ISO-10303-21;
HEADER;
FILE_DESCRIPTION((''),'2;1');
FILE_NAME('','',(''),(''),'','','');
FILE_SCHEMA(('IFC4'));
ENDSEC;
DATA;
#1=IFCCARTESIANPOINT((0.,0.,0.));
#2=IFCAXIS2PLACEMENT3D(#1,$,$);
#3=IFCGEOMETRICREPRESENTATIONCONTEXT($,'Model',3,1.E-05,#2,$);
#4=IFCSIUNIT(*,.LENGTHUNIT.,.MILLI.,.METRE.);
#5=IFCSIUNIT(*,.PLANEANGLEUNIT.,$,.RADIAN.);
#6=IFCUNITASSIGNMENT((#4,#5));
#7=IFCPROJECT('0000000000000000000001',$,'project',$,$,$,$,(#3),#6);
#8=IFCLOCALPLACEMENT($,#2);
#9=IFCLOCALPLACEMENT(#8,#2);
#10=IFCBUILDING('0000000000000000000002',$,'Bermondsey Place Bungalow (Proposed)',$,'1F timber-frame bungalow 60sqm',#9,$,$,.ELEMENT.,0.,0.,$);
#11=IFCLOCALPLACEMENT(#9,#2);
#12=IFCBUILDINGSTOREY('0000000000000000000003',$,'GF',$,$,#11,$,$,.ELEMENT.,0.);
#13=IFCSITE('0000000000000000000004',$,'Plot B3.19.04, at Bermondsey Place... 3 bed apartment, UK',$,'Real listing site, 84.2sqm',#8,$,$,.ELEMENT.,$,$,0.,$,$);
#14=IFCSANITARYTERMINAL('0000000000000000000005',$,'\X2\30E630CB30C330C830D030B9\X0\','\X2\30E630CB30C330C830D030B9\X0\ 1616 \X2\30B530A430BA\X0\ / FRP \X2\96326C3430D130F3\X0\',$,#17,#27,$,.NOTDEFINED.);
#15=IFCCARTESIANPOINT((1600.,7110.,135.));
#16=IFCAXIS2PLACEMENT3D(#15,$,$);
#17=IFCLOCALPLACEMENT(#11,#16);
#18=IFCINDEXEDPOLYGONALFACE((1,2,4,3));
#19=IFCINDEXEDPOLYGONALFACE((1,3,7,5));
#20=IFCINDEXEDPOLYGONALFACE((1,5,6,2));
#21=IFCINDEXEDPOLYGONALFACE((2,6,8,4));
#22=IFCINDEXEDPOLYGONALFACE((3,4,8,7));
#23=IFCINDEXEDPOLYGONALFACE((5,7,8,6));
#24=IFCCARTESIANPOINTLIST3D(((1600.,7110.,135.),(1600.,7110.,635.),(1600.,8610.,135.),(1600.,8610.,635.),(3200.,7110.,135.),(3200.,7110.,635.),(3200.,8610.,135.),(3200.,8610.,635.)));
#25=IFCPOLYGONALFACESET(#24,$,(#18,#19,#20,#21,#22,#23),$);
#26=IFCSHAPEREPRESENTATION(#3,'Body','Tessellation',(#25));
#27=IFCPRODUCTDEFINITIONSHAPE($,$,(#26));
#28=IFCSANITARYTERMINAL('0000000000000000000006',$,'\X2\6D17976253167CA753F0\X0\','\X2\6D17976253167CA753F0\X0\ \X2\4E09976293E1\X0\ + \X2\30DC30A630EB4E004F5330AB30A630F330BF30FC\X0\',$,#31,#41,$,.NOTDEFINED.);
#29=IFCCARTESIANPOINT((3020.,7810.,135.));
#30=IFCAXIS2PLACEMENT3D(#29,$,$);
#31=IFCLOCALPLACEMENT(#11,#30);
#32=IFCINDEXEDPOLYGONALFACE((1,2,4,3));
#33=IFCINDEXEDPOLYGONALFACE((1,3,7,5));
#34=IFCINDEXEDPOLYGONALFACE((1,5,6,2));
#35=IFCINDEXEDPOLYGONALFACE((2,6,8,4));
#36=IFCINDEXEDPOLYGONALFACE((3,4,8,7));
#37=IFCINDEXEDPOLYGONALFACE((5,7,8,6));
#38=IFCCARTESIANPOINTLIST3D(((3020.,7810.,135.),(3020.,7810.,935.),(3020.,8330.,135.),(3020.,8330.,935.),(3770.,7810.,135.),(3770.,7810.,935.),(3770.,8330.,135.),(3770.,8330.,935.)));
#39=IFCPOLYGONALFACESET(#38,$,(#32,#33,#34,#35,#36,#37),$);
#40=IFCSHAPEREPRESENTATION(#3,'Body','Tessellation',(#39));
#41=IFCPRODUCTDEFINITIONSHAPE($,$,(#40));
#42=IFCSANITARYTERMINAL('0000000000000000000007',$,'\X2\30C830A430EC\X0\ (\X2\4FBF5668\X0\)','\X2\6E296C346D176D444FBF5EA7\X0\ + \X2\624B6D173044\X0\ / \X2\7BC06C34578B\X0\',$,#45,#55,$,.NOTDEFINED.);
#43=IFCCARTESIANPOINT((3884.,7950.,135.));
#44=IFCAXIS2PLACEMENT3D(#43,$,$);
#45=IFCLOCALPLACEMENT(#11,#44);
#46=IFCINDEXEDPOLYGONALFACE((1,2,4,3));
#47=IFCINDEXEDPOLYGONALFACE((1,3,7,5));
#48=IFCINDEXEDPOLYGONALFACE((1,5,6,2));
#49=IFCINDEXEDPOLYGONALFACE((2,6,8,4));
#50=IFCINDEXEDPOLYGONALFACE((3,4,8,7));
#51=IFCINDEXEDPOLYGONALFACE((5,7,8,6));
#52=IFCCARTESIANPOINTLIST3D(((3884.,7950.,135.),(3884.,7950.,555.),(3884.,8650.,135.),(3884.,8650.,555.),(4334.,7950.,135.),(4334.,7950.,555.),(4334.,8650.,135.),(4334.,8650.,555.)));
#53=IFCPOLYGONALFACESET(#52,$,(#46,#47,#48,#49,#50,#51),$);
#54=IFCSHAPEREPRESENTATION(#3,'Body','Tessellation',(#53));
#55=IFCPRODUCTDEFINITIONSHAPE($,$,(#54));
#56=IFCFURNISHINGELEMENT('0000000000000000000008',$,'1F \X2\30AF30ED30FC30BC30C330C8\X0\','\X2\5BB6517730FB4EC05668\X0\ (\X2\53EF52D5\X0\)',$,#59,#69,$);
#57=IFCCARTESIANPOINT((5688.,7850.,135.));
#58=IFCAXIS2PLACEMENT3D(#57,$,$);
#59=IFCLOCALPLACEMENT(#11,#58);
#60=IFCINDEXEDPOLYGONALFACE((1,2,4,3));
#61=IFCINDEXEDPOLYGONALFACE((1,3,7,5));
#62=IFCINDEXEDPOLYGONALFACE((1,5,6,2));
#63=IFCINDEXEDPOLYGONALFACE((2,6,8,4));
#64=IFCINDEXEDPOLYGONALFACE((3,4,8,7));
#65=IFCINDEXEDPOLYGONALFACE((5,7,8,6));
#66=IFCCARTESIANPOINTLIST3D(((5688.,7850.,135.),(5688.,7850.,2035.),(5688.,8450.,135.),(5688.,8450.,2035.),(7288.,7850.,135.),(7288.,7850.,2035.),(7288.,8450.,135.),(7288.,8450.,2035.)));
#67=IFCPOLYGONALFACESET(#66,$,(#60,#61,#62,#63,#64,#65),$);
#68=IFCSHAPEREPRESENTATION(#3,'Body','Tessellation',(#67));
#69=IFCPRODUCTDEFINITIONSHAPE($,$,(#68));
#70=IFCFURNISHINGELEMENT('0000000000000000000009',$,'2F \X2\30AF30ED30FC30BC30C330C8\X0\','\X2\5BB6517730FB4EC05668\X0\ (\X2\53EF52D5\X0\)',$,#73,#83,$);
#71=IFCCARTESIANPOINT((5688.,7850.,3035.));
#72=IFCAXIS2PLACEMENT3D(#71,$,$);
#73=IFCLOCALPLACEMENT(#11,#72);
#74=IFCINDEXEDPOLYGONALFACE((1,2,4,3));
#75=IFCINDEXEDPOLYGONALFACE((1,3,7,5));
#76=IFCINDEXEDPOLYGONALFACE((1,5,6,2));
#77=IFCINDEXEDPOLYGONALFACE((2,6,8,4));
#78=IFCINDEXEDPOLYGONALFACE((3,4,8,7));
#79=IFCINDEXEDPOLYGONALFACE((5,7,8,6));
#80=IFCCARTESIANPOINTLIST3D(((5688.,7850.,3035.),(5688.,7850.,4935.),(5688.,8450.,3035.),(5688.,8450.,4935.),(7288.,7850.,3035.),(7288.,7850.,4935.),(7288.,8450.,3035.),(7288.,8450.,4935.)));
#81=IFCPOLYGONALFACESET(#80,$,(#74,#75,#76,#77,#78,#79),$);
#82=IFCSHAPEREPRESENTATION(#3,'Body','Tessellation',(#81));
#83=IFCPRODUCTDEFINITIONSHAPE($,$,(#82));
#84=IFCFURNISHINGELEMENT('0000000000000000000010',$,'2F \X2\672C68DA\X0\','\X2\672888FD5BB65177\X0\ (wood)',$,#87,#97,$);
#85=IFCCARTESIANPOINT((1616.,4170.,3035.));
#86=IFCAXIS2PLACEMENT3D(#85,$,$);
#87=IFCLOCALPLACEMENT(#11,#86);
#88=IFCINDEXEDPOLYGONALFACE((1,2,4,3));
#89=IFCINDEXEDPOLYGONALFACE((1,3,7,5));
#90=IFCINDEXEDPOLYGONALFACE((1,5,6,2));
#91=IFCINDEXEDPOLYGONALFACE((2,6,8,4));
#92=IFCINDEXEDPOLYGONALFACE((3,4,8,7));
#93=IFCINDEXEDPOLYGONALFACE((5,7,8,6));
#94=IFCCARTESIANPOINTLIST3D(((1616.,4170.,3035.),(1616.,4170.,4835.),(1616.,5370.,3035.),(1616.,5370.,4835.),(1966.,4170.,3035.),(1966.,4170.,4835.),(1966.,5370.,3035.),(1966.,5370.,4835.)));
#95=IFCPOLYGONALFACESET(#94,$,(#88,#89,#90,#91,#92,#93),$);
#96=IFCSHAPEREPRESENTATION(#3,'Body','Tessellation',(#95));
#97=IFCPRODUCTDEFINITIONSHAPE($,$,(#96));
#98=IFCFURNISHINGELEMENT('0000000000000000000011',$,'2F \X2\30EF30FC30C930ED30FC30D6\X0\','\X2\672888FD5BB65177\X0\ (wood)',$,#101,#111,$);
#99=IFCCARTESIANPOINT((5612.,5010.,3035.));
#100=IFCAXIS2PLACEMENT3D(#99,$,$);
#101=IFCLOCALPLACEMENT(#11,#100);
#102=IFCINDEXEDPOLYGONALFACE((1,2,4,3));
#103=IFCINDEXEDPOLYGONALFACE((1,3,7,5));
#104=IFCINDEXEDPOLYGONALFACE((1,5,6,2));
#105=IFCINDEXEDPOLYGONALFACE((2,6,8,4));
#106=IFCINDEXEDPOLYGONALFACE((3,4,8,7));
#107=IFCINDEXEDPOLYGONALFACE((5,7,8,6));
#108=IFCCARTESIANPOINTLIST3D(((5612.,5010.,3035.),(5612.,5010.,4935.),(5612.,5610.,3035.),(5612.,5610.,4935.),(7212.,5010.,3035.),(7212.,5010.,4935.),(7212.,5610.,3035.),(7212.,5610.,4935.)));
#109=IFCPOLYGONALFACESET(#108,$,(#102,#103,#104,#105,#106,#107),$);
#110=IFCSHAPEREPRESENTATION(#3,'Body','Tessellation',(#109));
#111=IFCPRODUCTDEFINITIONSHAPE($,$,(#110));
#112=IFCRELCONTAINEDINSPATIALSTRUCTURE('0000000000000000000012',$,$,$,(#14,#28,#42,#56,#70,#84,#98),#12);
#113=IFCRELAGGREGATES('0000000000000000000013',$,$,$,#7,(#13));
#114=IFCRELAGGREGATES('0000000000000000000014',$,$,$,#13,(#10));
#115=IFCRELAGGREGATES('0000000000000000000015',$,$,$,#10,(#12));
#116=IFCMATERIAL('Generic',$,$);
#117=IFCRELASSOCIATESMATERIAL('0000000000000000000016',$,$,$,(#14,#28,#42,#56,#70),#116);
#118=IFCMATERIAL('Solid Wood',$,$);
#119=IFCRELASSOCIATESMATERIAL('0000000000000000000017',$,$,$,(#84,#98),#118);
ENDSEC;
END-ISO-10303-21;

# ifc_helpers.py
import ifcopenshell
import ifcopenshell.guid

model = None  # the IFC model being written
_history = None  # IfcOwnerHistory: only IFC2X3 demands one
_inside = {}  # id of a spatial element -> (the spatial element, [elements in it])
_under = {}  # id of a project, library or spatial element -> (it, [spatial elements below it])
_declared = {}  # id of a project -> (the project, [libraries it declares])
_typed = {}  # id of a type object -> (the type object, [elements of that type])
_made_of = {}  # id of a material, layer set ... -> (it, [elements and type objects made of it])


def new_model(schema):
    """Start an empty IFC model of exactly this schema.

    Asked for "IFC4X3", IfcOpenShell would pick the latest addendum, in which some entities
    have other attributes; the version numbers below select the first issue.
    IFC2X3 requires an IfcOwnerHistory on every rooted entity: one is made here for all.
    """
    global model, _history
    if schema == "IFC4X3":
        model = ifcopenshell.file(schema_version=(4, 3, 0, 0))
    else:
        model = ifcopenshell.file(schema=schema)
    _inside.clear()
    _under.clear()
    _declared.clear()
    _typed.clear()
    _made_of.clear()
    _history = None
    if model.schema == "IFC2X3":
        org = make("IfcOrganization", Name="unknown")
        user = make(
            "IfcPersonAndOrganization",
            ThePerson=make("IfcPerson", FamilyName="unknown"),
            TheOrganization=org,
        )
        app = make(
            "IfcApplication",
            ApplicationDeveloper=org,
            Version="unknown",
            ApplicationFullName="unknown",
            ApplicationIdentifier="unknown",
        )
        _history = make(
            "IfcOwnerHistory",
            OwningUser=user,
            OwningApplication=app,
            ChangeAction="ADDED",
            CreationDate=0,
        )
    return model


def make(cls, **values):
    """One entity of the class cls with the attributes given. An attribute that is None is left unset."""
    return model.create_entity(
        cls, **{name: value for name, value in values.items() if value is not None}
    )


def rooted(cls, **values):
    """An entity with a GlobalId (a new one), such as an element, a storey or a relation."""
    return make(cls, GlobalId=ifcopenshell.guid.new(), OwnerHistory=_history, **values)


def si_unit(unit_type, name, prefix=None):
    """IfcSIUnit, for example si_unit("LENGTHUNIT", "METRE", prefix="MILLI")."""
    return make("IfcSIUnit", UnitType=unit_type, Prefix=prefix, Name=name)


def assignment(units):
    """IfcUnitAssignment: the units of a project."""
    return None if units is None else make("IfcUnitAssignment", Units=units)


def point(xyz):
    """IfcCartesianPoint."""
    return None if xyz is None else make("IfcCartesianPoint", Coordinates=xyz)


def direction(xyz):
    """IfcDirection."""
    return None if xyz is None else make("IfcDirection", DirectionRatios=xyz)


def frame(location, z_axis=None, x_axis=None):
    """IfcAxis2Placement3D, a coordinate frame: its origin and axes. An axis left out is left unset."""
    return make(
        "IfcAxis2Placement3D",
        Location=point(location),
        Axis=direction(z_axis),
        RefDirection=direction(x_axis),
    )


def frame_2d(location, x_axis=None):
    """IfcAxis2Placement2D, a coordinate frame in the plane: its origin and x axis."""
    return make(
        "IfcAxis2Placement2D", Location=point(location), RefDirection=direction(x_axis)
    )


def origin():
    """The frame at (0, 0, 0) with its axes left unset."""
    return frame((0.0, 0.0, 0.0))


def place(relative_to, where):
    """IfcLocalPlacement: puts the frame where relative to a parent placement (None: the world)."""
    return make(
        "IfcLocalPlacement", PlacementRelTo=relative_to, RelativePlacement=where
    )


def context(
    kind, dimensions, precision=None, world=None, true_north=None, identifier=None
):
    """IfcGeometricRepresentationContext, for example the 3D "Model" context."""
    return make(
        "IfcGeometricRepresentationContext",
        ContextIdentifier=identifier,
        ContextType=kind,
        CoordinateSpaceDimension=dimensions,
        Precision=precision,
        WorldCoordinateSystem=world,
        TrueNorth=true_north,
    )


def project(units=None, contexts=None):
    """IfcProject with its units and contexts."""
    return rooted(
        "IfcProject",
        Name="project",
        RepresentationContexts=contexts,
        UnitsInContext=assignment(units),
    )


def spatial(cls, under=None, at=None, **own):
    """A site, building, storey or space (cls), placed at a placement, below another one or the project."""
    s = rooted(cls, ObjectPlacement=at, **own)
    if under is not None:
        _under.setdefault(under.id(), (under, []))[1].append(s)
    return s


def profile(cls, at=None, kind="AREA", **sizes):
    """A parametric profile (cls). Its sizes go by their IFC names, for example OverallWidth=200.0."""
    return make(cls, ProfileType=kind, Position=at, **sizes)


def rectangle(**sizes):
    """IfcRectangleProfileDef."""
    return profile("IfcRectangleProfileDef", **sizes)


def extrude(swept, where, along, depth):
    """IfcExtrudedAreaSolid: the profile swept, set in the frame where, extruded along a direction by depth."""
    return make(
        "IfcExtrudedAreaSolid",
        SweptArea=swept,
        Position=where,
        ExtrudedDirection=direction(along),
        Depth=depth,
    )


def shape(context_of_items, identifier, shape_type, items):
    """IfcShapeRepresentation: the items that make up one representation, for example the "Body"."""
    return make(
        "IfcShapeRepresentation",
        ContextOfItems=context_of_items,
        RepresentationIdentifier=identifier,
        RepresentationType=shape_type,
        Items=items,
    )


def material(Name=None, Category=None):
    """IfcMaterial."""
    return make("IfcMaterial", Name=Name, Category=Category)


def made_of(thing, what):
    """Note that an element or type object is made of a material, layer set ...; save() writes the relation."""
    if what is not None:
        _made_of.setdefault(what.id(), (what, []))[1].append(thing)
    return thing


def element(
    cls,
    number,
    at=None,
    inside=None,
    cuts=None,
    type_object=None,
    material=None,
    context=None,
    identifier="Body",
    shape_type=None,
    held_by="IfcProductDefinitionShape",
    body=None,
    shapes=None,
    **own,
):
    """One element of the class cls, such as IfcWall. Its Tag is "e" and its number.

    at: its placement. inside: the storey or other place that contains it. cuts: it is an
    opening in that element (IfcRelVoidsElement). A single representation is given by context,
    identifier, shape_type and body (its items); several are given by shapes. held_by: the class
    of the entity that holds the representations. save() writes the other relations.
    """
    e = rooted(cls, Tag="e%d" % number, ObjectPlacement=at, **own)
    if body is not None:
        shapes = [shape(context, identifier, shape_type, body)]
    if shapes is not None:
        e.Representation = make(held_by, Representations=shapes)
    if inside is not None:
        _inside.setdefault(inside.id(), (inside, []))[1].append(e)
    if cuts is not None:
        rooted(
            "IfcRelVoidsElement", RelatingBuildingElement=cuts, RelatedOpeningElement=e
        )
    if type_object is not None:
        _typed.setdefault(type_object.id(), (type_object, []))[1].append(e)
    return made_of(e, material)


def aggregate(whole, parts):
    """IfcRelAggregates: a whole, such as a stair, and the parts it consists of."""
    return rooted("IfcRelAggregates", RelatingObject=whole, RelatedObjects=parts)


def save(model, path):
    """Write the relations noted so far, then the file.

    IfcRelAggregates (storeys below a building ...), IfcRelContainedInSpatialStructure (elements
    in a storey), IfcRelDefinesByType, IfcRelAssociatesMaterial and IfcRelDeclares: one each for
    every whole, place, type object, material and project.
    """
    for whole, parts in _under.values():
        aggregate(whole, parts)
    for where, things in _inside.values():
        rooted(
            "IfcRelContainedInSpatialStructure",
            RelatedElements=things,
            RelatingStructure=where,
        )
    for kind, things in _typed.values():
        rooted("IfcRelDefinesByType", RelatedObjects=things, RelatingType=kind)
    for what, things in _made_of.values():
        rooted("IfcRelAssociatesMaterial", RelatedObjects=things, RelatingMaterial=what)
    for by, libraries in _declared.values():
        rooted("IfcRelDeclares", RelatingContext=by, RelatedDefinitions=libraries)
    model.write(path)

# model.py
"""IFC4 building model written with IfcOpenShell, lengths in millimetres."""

from ifc_helpers import new_model, si_unit, frame, frame_2d, origin, place, context, project, spatial, rectangle, extrude, material, element, save


model = new_model("IFC4")

# Units and contexts
model_context = context("Model", 3, precision=1e-05, world=origin())
ifc_project = project(units=[si_unit("LENGTHUNIT", "METRE", prefix="MILLI"), si_unit("PLANEANGLEUNIT", "RADIAN")], contexts=[model_context])

# Site, building, storey
site_placement = place(None, origin())
site = spatial("IfcSite", under=ifc_project, at=site_placement, Name="Plot B3.19.04, at Bermondsey Place... 3 bed apartment, UK", ObjectType="Real listing site, 84.2sqm", CompositionType="ELEMENT", RefElevation=0.0)
building_placement = place(site_placement, origin())
building = spatial("IfcBuilding", under=site, at=building_placement, Name="Bermondsey Place Bungalow (Proposed)", ObjectType="1F timber-frame bungalow 60sqm", CompositionType="ELEMENT", ElevationOfRefHeight=0.0, ElevationOfTerrain=0.0)
storey_placement = place(building_placement, origin())
storey = spatial("IfcBuildingStorey", under=building, at=storey_placement, Name="GF", CompositionType="ELEMENT", Elevation=0.0)

# Shared definitions
ifc_material_1 = material(Name="Solid Wood")

# Shared definitions
ifc_material_2 = material(Name="Generic")

# Sanitary terminals
sanitary_terminal_1_placement = place(storey_placement, frame((1600.0, 7110.0, 135.0)))
element("IfcSanitaryTerminal", 1, at=sanitary_terminal_1_placement, inside=storey, material=ifc_material_2, Name="ユニットバス", Description="ユニットバス 1616 サイズ / FRP 防水パン", PredefinedType="NOTDEFINED", context=model_context, shape_type="SweptSolid", body=[
    extrude(rectangle(XDim=1600.0, YDim=1500.0, at=frame_2d((800.0, 750.0))), frame((1600.0, 7110.0, 135.0)), (0.0, 0.0, 1.0), 500.0),
])
sanitary_terminal_2_placement = place(storey_placement, frame((3020.0, 7810.0, 135.0)))
element("IfcSanitaryTerminal", 2, at=sanitary_terminal_2_placement, inside=storey, material=ifc_material_2, Name="洗面化粧台", Description="洗面化粧台 三面鏡 + ボウル一体カウンター", PredefinedType="NOTDEFINED", context=model_context, shape_type="SweptSolid", body=[
    extrude(rectangle(XDim=750.0, YDim=520.0, at=frame_2d((375.0, 260.0))), frame((3020.0, 7810.0, 135.0)), (0.0, 0.0, 1.0), 800.0),
])
sanitary_terminal_3_placement = place(storey_placement, frame((3884.0, 7950.0, 135.0)))
element("IfcSanitaryTerminal", 3, at=sanitary_terminal_3_placement, inside=storey, material=ifc_material_2, Name="トイレ (便器)", Description="温水洗浄便座 + 手洗い / 節水型", PredefinedType="NOTDEFINED", context=model_context, shape_type="SweptSolid", body=[
    extrude(rectangle(XDim=450.0, YDim=700.0, at=frame_2d((225.0, 350.0))), frame((3884.0, 7950.0, 135.0)), (0.0, 0.0, 1.0), 420.0),
])

# Furnishing elements
furnishing_1_placement = place(storey_placement, frame((5688.0, 7850.0, 135.0)))
element("IfcFurnishingElement", 4, at=furnishing_1_placement, inside=storey, material=ifc_material_2, Name="1F クローゼット", Description="家具・什器 (可動)", context=model_context, shape_type="SweptSolid", body=[
    extrude(rectangle(XDim=1600.0, YDim=600.0, at=frame_2d((800.0, 300.0))), frame((5688.0, 7850.0, 135.0)), (0.0, 0.0, 1.0), 1900.0),
])
furnishing_2_placement = place(storey_placement, frame((5688.0, 7850.0, 3035.0)))
element("IfcFurnishingElement", 5, at=furnishing_2_placement, inside=storey, material=ifc_material_2, Name="2F クローゼット", Description="家具・什器 (可動)", context=model_context, shape_type="SweptSolid", body=[
    extrude(rectangle(XDim=1600.0, YDim=600.0, at=frame_2d((800.0, 300.0))), frame((5688.0, 7850.0, 3035.0)), (0.0, 0.0, 1.0), 1900.0),
])
furnishing_3_placement = place(storey_placement, frame((1616.0, 4170.0, 3035.0)))
element("IfcFurnishingElement", 6, at=furnishing_3_placement, inside=storey, material=ifc_material_1, Name="2F 本棚", Description="木製家具 (wood)", context=model_context, shape_type="SweptSolid", body=[
    extrude(rectangle(XDim=350.0, YDim=1200.0, at=frame_2d((175.0, 600.0))), frame((1616.0, 4170.0, 3035.0)), (0.0, 0.0, 1.0), 1800.0),
])
furnishing_4_placement = place(storey_placement, frame((5612.0, 5010.0, 3035.0)))
element("IfcFurnishingElement", 7, at=furnishing_4_placement, inside=storey, material=ifc_material_1, Name="2F ワードローブ", Description="木製家具 (wood)", context=model_context, shape_type="SweptSolid", body=[
    extrude(rectangle(XDim=1600.0, YDim=600.0, at=frame_2d((800.0, 300.0))), frame((5612.0, 5010.0, 3035.0)), (0.0, 0.0, 1.0), 1900.0),
])

save(model, "model.ifc")
